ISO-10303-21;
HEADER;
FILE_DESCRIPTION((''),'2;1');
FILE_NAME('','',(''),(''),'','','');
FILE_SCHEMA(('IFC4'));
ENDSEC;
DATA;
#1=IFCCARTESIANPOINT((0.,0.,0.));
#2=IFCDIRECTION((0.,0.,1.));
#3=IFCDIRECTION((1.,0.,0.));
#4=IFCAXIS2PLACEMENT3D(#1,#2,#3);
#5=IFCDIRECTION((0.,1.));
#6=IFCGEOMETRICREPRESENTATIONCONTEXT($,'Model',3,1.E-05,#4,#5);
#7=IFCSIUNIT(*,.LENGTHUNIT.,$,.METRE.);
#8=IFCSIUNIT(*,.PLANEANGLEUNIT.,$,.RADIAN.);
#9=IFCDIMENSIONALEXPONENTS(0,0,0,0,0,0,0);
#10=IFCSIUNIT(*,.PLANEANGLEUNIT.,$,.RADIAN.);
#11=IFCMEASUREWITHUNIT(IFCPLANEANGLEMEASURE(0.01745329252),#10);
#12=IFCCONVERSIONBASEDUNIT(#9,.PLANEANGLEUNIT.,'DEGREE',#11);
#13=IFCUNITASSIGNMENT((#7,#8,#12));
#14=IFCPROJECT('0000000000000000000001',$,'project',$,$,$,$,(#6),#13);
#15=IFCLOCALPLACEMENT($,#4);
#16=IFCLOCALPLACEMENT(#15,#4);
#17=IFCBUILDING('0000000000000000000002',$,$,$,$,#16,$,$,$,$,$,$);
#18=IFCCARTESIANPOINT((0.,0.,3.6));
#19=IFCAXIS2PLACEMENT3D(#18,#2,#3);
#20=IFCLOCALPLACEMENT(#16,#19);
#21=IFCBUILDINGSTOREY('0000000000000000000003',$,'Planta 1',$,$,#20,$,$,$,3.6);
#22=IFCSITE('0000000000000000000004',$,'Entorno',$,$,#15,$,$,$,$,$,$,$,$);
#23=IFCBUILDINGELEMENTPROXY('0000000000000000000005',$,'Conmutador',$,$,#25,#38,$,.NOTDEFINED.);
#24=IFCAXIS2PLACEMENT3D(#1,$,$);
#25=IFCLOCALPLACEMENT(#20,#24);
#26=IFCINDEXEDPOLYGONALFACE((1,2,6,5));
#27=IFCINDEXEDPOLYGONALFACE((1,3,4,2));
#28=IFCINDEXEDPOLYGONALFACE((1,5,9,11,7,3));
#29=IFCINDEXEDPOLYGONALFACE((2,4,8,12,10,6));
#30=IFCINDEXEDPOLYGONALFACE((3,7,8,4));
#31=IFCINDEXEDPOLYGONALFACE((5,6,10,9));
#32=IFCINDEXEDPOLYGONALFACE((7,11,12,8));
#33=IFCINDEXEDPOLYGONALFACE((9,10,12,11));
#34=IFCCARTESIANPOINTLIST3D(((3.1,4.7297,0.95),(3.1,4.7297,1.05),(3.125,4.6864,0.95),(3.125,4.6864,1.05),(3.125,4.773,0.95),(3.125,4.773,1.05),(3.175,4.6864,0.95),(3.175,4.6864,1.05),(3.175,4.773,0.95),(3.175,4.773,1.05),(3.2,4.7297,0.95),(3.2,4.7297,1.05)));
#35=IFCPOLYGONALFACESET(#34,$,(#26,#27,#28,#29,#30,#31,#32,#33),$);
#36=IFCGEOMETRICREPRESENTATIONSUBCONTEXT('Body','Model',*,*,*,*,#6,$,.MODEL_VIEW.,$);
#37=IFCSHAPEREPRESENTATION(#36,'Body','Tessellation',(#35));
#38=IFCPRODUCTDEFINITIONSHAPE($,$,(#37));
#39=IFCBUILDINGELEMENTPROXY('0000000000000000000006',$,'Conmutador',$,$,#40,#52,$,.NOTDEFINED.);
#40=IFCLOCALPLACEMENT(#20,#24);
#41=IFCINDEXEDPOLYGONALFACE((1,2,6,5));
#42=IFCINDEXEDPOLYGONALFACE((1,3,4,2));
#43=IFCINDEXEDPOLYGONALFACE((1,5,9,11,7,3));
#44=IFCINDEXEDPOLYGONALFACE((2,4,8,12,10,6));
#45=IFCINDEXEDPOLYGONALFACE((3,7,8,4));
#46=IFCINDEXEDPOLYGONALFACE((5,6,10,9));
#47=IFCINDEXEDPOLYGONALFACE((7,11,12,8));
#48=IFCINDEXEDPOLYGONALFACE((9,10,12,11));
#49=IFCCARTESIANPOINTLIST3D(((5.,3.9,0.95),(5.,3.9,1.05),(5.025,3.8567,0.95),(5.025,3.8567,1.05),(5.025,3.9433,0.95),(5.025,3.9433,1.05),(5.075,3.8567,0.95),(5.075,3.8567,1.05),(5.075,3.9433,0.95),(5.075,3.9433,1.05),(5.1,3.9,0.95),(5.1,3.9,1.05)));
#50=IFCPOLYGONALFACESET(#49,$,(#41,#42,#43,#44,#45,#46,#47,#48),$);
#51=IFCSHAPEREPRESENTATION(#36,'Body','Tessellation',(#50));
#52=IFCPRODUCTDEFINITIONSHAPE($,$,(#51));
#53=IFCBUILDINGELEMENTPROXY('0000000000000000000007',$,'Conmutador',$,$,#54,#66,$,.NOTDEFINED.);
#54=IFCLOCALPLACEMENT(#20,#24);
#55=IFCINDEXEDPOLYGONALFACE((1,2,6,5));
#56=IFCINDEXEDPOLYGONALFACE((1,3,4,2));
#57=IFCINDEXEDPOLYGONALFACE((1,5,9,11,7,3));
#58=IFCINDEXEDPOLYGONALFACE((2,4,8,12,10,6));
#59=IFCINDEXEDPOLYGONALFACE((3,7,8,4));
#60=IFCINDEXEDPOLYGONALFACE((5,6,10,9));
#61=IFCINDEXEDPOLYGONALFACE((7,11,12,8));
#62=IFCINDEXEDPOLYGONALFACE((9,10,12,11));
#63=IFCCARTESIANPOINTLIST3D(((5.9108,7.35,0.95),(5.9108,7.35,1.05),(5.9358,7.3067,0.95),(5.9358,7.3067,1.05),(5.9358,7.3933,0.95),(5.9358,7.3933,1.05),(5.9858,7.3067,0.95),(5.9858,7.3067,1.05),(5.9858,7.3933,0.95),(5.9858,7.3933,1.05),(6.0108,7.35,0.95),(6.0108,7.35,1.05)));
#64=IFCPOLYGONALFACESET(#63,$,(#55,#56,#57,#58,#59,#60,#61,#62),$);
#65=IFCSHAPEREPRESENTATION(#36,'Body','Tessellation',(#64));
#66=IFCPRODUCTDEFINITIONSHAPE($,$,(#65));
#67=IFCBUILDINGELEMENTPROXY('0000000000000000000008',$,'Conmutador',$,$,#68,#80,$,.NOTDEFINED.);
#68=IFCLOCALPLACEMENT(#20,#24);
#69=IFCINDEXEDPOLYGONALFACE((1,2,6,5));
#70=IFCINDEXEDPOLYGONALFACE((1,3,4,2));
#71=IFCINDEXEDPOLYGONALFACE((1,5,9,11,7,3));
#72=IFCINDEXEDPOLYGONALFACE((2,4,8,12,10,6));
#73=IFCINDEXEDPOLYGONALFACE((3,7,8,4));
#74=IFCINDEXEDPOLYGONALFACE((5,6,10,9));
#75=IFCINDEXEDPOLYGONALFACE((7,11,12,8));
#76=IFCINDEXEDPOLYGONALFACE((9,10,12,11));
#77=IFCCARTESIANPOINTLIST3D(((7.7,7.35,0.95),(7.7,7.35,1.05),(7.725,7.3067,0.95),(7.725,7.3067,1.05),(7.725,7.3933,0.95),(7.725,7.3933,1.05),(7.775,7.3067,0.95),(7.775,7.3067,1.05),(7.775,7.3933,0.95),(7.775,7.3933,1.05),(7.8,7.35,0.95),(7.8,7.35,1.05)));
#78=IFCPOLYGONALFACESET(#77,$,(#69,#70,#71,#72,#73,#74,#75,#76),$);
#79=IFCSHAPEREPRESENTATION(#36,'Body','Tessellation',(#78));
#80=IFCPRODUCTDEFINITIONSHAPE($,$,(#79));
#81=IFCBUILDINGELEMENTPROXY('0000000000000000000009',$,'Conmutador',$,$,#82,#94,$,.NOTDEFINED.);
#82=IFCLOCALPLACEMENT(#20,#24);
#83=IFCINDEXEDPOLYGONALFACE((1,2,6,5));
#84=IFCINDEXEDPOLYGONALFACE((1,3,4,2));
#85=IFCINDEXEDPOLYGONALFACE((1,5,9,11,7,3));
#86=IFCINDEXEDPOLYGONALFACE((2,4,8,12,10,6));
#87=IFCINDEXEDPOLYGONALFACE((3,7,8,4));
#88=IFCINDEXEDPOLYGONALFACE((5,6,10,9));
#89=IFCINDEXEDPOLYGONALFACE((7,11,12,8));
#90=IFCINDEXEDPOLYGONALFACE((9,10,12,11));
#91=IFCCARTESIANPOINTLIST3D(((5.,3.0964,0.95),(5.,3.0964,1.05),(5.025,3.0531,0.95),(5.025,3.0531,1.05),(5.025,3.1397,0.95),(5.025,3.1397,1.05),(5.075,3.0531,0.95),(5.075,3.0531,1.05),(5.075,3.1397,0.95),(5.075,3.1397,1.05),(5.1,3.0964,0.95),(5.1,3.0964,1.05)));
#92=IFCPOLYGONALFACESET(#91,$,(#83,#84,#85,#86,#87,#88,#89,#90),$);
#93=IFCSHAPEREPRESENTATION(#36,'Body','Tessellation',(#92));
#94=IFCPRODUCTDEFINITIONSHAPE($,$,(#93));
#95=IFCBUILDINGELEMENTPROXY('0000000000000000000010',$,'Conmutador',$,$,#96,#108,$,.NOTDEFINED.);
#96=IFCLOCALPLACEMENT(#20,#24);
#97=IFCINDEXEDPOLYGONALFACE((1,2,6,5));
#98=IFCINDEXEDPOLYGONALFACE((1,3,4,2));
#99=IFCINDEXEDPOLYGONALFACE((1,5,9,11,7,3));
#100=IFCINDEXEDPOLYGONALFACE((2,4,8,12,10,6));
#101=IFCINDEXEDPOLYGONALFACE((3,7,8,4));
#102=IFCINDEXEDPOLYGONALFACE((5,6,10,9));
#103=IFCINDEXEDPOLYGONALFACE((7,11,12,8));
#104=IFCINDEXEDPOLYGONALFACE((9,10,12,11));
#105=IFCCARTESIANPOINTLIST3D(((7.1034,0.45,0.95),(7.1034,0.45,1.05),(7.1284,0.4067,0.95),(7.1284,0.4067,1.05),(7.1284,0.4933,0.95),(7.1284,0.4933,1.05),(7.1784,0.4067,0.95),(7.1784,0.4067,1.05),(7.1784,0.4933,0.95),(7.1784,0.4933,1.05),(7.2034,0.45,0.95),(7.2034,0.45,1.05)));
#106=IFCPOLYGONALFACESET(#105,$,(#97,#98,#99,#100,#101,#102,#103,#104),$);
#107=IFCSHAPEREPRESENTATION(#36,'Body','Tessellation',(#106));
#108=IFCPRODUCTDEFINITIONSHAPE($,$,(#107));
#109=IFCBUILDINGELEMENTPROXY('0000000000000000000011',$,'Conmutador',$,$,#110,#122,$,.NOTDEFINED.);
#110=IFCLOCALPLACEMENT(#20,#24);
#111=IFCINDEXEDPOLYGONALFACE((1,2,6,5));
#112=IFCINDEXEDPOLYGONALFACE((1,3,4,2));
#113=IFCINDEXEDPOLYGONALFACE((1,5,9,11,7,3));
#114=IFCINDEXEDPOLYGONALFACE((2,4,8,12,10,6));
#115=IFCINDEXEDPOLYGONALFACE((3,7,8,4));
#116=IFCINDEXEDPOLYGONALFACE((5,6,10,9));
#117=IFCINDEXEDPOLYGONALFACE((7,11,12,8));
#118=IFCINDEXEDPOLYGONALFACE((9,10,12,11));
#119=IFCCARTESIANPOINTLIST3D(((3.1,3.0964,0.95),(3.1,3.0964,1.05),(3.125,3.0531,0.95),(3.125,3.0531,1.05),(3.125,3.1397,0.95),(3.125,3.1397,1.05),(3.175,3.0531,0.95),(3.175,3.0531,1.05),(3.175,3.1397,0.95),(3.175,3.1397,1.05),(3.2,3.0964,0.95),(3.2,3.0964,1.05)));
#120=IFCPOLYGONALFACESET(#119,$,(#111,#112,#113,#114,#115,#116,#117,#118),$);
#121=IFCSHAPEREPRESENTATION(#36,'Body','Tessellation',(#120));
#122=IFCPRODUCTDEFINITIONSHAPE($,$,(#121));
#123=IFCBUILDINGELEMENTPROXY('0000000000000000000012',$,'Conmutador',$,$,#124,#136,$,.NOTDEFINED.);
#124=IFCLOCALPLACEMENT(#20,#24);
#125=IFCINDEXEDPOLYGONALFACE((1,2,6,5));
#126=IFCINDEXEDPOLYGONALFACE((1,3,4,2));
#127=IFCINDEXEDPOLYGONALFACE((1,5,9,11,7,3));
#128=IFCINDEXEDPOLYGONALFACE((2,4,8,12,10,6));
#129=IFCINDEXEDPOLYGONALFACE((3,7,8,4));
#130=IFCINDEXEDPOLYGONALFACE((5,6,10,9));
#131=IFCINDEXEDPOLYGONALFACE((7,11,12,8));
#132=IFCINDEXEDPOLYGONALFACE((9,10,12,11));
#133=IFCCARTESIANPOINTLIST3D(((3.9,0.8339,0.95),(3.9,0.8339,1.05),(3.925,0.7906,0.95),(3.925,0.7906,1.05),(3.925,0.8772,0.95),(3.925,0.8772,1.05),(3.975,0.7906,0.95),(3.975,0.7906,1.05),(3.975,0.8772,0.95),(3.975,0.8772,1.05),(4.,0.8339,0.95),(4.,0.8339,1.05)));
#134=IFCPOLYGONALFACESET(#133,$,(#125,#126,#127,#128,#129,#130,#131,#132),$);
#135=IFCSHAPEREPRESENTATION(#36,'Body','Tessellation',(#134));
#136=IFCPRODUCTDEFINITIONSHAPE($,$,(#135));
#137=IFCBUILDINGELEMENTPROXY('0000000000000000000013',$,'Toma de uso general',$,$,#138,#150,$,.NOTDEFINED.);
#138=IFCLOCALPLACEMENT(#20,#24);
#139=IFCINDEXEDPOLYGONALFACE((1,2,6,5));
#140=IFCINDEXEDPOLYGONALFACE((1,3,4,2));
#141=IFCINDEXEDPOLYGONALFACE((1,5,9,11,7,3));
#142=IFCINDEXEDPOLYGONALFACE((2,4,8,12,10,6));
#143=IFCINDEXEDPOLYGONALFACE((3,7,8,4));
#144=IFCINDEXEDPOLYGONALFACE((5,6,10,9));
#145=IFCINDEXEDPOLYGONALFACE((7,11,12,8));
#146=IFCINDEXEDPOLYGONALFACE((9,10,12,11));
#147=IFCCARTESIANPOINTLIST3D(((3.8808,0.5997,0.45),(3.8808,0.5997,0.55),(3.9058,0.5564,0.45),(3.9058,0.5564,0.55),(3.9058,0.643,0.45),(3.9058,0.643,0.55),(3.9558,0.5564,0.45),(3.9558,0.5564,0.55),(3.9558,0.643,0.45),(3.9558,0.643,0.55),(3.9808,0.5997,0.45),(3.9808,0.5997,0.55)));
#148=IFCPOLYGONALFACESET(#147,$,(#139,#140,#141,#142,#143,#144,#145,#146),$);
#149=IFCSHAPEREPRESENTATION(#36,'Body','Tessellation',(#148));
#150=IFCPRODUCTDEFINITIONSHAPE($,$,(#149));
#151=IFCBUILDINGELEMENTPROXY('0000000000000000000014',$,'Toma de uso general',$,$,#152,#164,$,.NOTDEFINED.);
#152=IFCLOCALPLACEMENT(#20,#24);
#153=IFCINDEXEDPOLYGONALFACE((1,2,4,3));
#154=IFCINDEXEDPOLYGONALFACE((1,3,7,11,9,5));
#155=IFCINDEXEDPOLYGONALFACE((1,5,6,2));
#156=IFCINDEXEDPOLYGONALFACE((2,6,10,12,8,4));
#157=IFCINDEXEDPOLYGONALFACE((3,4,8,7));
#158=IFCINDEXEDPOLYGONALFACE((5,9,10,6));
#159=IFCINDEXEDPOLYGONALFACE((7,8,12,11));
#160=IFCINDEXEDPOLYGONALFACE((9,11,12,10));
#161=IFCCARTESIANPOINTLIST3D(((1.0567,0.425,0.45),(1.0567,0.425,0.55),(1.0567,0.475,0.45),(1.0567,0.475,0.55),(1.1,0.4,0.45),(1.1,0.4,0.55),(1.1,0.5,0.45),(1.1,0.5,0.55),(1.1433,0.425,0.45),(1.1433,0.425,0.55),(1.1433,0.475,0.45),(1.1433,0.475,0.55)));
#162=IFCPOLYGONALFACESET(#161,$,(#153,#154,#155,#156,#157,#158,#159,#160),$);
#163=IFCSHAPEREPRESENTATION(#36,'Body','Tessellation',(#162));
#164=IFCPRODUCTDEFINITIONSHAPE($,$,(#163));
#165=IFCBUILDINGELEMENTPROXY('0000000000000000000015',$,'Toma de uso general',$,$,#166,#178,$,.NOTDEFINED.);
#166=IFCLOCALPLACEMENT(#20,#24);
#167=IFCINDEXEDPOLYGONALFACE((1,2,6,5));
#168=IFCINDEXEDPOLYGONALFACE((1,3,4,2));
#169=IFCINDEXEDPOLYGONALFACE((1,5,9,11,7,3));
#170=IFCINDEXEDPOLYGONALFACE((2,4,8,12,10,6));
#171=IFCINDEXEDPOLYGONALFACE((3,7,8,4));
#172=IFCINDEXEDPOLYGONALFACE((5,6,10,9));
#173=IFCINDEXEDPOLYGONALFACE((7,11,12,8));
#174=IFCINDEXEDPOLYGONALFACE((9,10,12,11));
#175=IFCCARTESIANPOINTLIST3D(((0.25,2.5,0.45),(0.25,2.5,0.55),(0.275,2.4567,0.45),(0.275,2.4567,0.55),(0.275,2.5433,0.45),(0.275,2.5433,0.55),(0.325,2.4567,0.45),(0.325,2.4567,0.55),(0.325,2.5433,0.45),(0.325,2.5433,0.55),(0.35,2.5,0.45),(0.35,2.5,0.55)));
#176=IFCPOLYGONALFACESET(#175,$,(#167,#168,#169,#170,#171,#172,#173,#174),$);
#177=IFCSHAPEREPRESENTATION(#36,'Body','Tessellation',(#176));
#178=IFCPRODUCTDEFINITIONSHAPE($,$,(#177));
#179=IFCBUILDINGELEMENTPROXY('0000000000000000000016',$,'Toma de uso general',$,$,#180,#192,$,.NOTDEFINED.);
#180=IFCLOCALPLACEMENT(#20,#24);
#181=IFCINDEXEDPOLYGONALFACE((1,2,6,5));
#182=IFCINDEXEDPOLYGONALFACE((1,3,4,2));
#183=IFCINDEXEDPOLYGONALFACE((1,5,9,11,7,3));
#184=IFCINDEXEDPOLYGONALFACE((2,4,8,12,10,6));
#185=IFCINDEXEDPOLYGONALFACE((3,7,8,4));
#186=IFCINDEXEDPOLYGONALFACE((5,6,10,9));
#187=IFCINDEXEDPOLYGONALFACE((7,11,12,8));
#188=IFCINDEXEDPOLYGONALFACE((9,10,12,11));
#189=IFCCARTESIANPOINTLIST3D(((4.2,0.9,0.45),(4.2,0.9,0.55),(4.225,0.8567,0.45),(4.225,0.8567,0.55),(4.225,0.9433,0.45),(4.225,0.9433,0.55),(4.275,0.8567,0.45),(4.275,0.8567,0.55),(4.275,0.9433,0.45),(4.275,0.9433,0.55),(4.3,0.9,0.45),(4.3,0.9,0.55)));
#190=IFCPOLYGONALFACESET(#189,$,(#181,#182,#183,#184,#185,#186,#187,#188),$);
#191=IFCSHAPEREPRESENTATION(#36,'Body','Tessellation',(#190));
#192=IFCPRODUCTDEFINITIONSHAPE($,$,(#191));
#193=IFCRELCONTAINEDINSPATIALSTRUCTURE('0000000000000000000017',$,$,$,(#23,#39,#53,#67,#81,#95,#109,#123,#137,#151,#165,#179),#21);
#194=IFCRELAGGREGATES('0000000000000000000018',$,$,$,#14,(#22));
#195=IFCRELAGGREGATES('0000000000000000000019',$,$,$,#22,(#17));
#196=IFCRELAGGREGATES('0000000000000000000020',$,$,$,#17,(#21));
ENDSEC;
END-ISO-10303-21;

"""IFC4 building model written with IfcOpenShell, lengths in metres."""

from ifc_helpers import new_model, entity, si_unit, converted_unit, direction, frame, origin_with_axes, place, context, subcontext, project, spatial, polyline, outline, extrude, source, transform, mapped, element, save


model = new_model("IFC4")

# Units and contexts
model_context = context("Model", 3, precision=1e-05, world=origin_with_axes(), true_north=direction((0.0, 1.0)))
body_context = subcontext(model_context, "Body", "Model", "MODEL_VIEW")
ifc_project = project(units=[si_unit("LENGTHUNIT", "METRE"), si_unit("PLANEANGLEUNIT", "RADIAN"), converted_unit("PLANEANGLEUNIT", "DEGREE", entity("IfcPlaneAngleMeasure", 0.01745329252), si_unit("PLANEANGLEUNIT", "RADIAN"), dimensions=[0, 0, 0, 0, 0, 0, 0])], contexts=[model_context])

# Site, building, storey
site_placement = place(None, origin_with_axes())
site = spatial("IfcSite", under=ifc_project, at=site_placement, Name="Entorno")
building_placement = place(site_placement, origin_with_axes())
building = spatial("IfcBuilding", under=site, at=building_placement)
storey_placement = place(building_placement, frame((0.0, 0.0, 3.6), z_axis=(0.0, 0.0, 1.0), x_axis=(1.0, 0.0, 0.0)))
storey = spatial("IfcBuildingStorey", under=building, at=storey_placement, Name="Planta 1", Elevation=3.6)

# Building element proxies
shared_shape_1 = source(origin_with_axes(), body_context, "Body", "SolidModel", [
    extrude(outline(polyline([(0.05, 0.0), (0.025, 0.0433), (-0.025, 0.0433), (-0.05, 0.0), (-0.025, -0.0433), (0.025, -0.0433), (0.05, 0.0)])), frame((0.0, 0.0, -0.05), z_axis=(0.0, 0.0, 1.0), x_axis=(1.0, 0.0, 0.0)), (0.0, 0.0, 1.0), 0.1),
])
proxy_1_placement = place(storey_placement, frame((0.0, 0.0, -3.6), z_axis=(0.0, 0.0, 1.0), x_axis=(1.0, 0.0, 0.0)))
element("IfcBuildingElementProxy", 1, at=proxy_1_placement, inside=storey, Name="Conmutador", PredefinedType="NOTDEFINED", context=body_context, shape_type="Brep", body=[
    mapped(shared_shape_1, transform((3.15, 4.7297, 4.6), x_axis=(1.0, 0.0, 0.0), y_axis=(0.0, 1.0, 0.0), z_axis=(0.0, 0.0, 1.0))),
])
proxy_2_placement = place(storey_placement, frame((0.0, 0.0, -3.6), z_axis=(0.0, 0.0, 1.0), x_axis=(1.0, 0.0, 0.0)))
element("IfcBuildingElementProxy", 2, at=proxy_2_placement, inside=storey, Name="Conmutador", PredefinedType="NOTDEFINED", context=body_context, shape_type="Brep", body=[
    mapped(shared_shape_1, transform((5.05, 3.9, 4.6), x_axis=(1.0, 0.0, 0.0), y_axis=(0.0, 1.0, 0.0), z_axis=(0.0, 0.0, 1.0))),
])
proxy_3_placement = place(storey_placement, frame((0.0, 0.0, -3.6), z_axis=(0.0, 0.0, 1.0), x_axis=(1.0, 0.0, 0.0)))
element("IfcBuildingElementProxy", 3, at=proxy_3_placement, inside=storey, Name="Conmutador", PredefinedType="NOTDEFINED", context=body_context, shape_type="Brep", body=[
    mapped(shared_shape_1, transform((5.9608, 7.35, 4.6), x_axis=(1.0, 0.0, 0.0), y_axis=(0.0, 1.0, 0.0), z_axis=(0.0, 0.0, 1.0))),
])
proxy_4_placement = place(storey_placement, frame((0.0, 0.0, -3.6), z_axis=(0.0, 0.0, 1.0), x_axis=(1.0, 0.0, 0.0)))
element("IfcBuildingElementProxy", 4, at=proxy_4_placement, inside=storey, Name="Conmutador", PredefinedType="NOTDEFINED", context=body_context, shape_type="Brep", body=[
    mapped(shared_shape_1, transform((7.75, 7.35, 4.6), x_axis=(1.0, 0.0, 0.0), y_axis=(0.0, 1.0, 0.0), z_axis=(0.0, 0.0, 1.0))),
])
proxy_5_placement = place(storey_placement, frame((0.0, 0.0, -3.6), z_axis=(0.0, 0.0, 1.0), x_axis=(1.0, 0.0, 0.0)))
element("IfcBuildingElementProxy", 5, at=proxy_5_placement, inside=storey, Name="Conmutador", PredefinedType="NOTDEFINED", context=body_context, shape_type="Brep", body=[
    mapped(shared_shape_1, transform((5.05, 3.0964, 4.6), x_axis=(1.0, 0.0, 0.0), y_axis=(0.0, 1.0, 0.0), z_axis=(0.0, 0.0, 1.0))),
])
proxy_6_placement = place(storey_placement, frame((0.0, 0.0, -3.6), z_axis=(0.0, 0.0, 1.0), x_axis=(1.0, 0.0, 0.0)))
element("IfcBuildingElementProxy", 6, at=proxy_6_placement, inside=storey, Name="Conmutador", PredefinedType="NOTDEFINED", context=body_context, shape_type="Brep", body=[
    mapped(shared_shape_1, transform((7.1534, 0.45, 4.6), x_axis=(1.0, 0.0, 0.0), y_axis=(0.0, 1.0, 0.0), z_axis=(0.0, 0.0, 1.0))),
])
proxy_7_placement = place(storey_placement, frame((0.0, 0.0, -3.6), z_axis=(0.0, 0.0, 1.0), x_axis=(1.0, 0.0, 0.0)))
element("IfcBuildingElementProxy", 7, at=proxy_7_placement, inside=storey, Name="Conmutador", PredefinedType="NOTDEFINED", context=body_context, shape_type="Brep", body=[
    mapped(shared_shape_1, transform((3.15, 3.0964, 4.6), x_axis=(1.0, 0.0, 0.0), y_axis=(0.0, 1.0, 0.0), z_axis=(0.0, 0.0, 1.0))),
])
proxy_8_placement = place(storey_placement, frame((0.0, 0.0, -3.6), z_axis=(0.0, 0.0, 1.0), x_axis=(1.0, 0.0, 0.0)))
element("IfcBuildingElementProxy", 8, at=proxy_8_placement, inside=storey, Name="Conmutador", PredefinedType="NOTDEFINED", context=body_context, shape_type="Brep", body=[
    mapped(shared_shape_1, transform((3.95, 0.8339, 4.6), x_axis=(1.0, 0.0, 0.0), y_axis=(0.0, 1.0, 0.0), z_axis=(0.0, 0.0, 1.0))),
])
shared_shape_2 = source(origin_with_axes(), body_context, "Body", "SolidModel", [
    extrude(outline(polyline([(0.05, 0.0), (0.025, 0.0433), (-0.025, 0.0433), (-0.05, 0.0), (-0.025, -0.0433), (0.025, -0.0433), (0.05, 0.0)])), frame((0.0, 0.0, -0.05), z_axis=(0.0, 0.0, 1.0), x_axis=(1.0, 0.0, 0.0)), (0.0, 0.0, 1.0), 0.1),
])
proxy_9_placement = place(storey_placement, frame((0.0, 0.0, -3.6), z_axis=(0.0, 0.0, 1.0), x_axis=(1.0, 0.0, 0.0)))
element("IfcBuildingElementProxy", 9, at=proxy_9_placement, inside=storey, Name="Toma de uso general", PredefinedType="NOTDEFINED", context=body_context, shape_type="Brep", body=[
    mapped(shared_shape_2, transform((3.9308, 0.5997, 4.1), x_axis=(-1.0, 0.0, 0.0), y_axis=(0.0, -1.0, 0.0), z_axis=(0.0, 0.0, 1.0))),
])
proxy_10_placement = place(storey_placement, frame((0.0, 0.0, -3.6), z_axis=(0.0, 0.0, 1.0), x_axis=(1.0, 0.0, 0.0)))
element("IfcBuildingElementProxy", 10, at=proxy_10_placement, inside=storey, Name="Toma de uso general", PredefinedType="NOTDEFINED", context=body_context, shape_type="Brep", body=[
    mapped(shared_shape_2, transform((1.1, 0.45, 4.1), x_axis=(0.0, 1.0, 0.0), y_axis=(-1.0, 0.0, 0.0), z_axis=(0.0, 0.0, 1.0))),
])
proxy_11_placement = place(storey_placement, frame((0.0, 0.0, -3.6), z_axis=(0.0, 0.0, 1.0), x_axis=(1.0, 0.0, 0.0)))
element("IfcBuildingElementProxy", 11, at=proxy_11_placement, inside=storey, Name="Toma de uso general", PredefinedType="NOTDEFINED", context=body_context, shape_type="Brep", body=[
    mapped(shared_shape_2, transform((0.3, 2.5, 4.1), x_axis=(1.0, 0.0, 0.0), y_axis=(0.0, 1.0, 0.0), z_axis=(0.0, 0.0, 1.0))),
])
proxy_12_placement = place(storey_placement, frame((0.0, 0.0, -3.6), z_axis=(0.0, 0.0, 1.0), x_axis=(1.0, 0.0, 0.0)))
element("IfcBuildingElementProxy", 12, at=proxy_12_placement, inside=storey, Name="Toma de uso general", PredefinedType="NOTDEFINED", context=body_context, shape_type="Brep", body=[
    mapped(shared_shape_2, transform((4.25, 0.9, 4.1), x_axis=(1.0, 0.0, 0.0), y_axis=(0.0, 1.0, 0.0), z_axis=(0.0, 0.0, 1.0))),
])

save(model, "model.ifc")
